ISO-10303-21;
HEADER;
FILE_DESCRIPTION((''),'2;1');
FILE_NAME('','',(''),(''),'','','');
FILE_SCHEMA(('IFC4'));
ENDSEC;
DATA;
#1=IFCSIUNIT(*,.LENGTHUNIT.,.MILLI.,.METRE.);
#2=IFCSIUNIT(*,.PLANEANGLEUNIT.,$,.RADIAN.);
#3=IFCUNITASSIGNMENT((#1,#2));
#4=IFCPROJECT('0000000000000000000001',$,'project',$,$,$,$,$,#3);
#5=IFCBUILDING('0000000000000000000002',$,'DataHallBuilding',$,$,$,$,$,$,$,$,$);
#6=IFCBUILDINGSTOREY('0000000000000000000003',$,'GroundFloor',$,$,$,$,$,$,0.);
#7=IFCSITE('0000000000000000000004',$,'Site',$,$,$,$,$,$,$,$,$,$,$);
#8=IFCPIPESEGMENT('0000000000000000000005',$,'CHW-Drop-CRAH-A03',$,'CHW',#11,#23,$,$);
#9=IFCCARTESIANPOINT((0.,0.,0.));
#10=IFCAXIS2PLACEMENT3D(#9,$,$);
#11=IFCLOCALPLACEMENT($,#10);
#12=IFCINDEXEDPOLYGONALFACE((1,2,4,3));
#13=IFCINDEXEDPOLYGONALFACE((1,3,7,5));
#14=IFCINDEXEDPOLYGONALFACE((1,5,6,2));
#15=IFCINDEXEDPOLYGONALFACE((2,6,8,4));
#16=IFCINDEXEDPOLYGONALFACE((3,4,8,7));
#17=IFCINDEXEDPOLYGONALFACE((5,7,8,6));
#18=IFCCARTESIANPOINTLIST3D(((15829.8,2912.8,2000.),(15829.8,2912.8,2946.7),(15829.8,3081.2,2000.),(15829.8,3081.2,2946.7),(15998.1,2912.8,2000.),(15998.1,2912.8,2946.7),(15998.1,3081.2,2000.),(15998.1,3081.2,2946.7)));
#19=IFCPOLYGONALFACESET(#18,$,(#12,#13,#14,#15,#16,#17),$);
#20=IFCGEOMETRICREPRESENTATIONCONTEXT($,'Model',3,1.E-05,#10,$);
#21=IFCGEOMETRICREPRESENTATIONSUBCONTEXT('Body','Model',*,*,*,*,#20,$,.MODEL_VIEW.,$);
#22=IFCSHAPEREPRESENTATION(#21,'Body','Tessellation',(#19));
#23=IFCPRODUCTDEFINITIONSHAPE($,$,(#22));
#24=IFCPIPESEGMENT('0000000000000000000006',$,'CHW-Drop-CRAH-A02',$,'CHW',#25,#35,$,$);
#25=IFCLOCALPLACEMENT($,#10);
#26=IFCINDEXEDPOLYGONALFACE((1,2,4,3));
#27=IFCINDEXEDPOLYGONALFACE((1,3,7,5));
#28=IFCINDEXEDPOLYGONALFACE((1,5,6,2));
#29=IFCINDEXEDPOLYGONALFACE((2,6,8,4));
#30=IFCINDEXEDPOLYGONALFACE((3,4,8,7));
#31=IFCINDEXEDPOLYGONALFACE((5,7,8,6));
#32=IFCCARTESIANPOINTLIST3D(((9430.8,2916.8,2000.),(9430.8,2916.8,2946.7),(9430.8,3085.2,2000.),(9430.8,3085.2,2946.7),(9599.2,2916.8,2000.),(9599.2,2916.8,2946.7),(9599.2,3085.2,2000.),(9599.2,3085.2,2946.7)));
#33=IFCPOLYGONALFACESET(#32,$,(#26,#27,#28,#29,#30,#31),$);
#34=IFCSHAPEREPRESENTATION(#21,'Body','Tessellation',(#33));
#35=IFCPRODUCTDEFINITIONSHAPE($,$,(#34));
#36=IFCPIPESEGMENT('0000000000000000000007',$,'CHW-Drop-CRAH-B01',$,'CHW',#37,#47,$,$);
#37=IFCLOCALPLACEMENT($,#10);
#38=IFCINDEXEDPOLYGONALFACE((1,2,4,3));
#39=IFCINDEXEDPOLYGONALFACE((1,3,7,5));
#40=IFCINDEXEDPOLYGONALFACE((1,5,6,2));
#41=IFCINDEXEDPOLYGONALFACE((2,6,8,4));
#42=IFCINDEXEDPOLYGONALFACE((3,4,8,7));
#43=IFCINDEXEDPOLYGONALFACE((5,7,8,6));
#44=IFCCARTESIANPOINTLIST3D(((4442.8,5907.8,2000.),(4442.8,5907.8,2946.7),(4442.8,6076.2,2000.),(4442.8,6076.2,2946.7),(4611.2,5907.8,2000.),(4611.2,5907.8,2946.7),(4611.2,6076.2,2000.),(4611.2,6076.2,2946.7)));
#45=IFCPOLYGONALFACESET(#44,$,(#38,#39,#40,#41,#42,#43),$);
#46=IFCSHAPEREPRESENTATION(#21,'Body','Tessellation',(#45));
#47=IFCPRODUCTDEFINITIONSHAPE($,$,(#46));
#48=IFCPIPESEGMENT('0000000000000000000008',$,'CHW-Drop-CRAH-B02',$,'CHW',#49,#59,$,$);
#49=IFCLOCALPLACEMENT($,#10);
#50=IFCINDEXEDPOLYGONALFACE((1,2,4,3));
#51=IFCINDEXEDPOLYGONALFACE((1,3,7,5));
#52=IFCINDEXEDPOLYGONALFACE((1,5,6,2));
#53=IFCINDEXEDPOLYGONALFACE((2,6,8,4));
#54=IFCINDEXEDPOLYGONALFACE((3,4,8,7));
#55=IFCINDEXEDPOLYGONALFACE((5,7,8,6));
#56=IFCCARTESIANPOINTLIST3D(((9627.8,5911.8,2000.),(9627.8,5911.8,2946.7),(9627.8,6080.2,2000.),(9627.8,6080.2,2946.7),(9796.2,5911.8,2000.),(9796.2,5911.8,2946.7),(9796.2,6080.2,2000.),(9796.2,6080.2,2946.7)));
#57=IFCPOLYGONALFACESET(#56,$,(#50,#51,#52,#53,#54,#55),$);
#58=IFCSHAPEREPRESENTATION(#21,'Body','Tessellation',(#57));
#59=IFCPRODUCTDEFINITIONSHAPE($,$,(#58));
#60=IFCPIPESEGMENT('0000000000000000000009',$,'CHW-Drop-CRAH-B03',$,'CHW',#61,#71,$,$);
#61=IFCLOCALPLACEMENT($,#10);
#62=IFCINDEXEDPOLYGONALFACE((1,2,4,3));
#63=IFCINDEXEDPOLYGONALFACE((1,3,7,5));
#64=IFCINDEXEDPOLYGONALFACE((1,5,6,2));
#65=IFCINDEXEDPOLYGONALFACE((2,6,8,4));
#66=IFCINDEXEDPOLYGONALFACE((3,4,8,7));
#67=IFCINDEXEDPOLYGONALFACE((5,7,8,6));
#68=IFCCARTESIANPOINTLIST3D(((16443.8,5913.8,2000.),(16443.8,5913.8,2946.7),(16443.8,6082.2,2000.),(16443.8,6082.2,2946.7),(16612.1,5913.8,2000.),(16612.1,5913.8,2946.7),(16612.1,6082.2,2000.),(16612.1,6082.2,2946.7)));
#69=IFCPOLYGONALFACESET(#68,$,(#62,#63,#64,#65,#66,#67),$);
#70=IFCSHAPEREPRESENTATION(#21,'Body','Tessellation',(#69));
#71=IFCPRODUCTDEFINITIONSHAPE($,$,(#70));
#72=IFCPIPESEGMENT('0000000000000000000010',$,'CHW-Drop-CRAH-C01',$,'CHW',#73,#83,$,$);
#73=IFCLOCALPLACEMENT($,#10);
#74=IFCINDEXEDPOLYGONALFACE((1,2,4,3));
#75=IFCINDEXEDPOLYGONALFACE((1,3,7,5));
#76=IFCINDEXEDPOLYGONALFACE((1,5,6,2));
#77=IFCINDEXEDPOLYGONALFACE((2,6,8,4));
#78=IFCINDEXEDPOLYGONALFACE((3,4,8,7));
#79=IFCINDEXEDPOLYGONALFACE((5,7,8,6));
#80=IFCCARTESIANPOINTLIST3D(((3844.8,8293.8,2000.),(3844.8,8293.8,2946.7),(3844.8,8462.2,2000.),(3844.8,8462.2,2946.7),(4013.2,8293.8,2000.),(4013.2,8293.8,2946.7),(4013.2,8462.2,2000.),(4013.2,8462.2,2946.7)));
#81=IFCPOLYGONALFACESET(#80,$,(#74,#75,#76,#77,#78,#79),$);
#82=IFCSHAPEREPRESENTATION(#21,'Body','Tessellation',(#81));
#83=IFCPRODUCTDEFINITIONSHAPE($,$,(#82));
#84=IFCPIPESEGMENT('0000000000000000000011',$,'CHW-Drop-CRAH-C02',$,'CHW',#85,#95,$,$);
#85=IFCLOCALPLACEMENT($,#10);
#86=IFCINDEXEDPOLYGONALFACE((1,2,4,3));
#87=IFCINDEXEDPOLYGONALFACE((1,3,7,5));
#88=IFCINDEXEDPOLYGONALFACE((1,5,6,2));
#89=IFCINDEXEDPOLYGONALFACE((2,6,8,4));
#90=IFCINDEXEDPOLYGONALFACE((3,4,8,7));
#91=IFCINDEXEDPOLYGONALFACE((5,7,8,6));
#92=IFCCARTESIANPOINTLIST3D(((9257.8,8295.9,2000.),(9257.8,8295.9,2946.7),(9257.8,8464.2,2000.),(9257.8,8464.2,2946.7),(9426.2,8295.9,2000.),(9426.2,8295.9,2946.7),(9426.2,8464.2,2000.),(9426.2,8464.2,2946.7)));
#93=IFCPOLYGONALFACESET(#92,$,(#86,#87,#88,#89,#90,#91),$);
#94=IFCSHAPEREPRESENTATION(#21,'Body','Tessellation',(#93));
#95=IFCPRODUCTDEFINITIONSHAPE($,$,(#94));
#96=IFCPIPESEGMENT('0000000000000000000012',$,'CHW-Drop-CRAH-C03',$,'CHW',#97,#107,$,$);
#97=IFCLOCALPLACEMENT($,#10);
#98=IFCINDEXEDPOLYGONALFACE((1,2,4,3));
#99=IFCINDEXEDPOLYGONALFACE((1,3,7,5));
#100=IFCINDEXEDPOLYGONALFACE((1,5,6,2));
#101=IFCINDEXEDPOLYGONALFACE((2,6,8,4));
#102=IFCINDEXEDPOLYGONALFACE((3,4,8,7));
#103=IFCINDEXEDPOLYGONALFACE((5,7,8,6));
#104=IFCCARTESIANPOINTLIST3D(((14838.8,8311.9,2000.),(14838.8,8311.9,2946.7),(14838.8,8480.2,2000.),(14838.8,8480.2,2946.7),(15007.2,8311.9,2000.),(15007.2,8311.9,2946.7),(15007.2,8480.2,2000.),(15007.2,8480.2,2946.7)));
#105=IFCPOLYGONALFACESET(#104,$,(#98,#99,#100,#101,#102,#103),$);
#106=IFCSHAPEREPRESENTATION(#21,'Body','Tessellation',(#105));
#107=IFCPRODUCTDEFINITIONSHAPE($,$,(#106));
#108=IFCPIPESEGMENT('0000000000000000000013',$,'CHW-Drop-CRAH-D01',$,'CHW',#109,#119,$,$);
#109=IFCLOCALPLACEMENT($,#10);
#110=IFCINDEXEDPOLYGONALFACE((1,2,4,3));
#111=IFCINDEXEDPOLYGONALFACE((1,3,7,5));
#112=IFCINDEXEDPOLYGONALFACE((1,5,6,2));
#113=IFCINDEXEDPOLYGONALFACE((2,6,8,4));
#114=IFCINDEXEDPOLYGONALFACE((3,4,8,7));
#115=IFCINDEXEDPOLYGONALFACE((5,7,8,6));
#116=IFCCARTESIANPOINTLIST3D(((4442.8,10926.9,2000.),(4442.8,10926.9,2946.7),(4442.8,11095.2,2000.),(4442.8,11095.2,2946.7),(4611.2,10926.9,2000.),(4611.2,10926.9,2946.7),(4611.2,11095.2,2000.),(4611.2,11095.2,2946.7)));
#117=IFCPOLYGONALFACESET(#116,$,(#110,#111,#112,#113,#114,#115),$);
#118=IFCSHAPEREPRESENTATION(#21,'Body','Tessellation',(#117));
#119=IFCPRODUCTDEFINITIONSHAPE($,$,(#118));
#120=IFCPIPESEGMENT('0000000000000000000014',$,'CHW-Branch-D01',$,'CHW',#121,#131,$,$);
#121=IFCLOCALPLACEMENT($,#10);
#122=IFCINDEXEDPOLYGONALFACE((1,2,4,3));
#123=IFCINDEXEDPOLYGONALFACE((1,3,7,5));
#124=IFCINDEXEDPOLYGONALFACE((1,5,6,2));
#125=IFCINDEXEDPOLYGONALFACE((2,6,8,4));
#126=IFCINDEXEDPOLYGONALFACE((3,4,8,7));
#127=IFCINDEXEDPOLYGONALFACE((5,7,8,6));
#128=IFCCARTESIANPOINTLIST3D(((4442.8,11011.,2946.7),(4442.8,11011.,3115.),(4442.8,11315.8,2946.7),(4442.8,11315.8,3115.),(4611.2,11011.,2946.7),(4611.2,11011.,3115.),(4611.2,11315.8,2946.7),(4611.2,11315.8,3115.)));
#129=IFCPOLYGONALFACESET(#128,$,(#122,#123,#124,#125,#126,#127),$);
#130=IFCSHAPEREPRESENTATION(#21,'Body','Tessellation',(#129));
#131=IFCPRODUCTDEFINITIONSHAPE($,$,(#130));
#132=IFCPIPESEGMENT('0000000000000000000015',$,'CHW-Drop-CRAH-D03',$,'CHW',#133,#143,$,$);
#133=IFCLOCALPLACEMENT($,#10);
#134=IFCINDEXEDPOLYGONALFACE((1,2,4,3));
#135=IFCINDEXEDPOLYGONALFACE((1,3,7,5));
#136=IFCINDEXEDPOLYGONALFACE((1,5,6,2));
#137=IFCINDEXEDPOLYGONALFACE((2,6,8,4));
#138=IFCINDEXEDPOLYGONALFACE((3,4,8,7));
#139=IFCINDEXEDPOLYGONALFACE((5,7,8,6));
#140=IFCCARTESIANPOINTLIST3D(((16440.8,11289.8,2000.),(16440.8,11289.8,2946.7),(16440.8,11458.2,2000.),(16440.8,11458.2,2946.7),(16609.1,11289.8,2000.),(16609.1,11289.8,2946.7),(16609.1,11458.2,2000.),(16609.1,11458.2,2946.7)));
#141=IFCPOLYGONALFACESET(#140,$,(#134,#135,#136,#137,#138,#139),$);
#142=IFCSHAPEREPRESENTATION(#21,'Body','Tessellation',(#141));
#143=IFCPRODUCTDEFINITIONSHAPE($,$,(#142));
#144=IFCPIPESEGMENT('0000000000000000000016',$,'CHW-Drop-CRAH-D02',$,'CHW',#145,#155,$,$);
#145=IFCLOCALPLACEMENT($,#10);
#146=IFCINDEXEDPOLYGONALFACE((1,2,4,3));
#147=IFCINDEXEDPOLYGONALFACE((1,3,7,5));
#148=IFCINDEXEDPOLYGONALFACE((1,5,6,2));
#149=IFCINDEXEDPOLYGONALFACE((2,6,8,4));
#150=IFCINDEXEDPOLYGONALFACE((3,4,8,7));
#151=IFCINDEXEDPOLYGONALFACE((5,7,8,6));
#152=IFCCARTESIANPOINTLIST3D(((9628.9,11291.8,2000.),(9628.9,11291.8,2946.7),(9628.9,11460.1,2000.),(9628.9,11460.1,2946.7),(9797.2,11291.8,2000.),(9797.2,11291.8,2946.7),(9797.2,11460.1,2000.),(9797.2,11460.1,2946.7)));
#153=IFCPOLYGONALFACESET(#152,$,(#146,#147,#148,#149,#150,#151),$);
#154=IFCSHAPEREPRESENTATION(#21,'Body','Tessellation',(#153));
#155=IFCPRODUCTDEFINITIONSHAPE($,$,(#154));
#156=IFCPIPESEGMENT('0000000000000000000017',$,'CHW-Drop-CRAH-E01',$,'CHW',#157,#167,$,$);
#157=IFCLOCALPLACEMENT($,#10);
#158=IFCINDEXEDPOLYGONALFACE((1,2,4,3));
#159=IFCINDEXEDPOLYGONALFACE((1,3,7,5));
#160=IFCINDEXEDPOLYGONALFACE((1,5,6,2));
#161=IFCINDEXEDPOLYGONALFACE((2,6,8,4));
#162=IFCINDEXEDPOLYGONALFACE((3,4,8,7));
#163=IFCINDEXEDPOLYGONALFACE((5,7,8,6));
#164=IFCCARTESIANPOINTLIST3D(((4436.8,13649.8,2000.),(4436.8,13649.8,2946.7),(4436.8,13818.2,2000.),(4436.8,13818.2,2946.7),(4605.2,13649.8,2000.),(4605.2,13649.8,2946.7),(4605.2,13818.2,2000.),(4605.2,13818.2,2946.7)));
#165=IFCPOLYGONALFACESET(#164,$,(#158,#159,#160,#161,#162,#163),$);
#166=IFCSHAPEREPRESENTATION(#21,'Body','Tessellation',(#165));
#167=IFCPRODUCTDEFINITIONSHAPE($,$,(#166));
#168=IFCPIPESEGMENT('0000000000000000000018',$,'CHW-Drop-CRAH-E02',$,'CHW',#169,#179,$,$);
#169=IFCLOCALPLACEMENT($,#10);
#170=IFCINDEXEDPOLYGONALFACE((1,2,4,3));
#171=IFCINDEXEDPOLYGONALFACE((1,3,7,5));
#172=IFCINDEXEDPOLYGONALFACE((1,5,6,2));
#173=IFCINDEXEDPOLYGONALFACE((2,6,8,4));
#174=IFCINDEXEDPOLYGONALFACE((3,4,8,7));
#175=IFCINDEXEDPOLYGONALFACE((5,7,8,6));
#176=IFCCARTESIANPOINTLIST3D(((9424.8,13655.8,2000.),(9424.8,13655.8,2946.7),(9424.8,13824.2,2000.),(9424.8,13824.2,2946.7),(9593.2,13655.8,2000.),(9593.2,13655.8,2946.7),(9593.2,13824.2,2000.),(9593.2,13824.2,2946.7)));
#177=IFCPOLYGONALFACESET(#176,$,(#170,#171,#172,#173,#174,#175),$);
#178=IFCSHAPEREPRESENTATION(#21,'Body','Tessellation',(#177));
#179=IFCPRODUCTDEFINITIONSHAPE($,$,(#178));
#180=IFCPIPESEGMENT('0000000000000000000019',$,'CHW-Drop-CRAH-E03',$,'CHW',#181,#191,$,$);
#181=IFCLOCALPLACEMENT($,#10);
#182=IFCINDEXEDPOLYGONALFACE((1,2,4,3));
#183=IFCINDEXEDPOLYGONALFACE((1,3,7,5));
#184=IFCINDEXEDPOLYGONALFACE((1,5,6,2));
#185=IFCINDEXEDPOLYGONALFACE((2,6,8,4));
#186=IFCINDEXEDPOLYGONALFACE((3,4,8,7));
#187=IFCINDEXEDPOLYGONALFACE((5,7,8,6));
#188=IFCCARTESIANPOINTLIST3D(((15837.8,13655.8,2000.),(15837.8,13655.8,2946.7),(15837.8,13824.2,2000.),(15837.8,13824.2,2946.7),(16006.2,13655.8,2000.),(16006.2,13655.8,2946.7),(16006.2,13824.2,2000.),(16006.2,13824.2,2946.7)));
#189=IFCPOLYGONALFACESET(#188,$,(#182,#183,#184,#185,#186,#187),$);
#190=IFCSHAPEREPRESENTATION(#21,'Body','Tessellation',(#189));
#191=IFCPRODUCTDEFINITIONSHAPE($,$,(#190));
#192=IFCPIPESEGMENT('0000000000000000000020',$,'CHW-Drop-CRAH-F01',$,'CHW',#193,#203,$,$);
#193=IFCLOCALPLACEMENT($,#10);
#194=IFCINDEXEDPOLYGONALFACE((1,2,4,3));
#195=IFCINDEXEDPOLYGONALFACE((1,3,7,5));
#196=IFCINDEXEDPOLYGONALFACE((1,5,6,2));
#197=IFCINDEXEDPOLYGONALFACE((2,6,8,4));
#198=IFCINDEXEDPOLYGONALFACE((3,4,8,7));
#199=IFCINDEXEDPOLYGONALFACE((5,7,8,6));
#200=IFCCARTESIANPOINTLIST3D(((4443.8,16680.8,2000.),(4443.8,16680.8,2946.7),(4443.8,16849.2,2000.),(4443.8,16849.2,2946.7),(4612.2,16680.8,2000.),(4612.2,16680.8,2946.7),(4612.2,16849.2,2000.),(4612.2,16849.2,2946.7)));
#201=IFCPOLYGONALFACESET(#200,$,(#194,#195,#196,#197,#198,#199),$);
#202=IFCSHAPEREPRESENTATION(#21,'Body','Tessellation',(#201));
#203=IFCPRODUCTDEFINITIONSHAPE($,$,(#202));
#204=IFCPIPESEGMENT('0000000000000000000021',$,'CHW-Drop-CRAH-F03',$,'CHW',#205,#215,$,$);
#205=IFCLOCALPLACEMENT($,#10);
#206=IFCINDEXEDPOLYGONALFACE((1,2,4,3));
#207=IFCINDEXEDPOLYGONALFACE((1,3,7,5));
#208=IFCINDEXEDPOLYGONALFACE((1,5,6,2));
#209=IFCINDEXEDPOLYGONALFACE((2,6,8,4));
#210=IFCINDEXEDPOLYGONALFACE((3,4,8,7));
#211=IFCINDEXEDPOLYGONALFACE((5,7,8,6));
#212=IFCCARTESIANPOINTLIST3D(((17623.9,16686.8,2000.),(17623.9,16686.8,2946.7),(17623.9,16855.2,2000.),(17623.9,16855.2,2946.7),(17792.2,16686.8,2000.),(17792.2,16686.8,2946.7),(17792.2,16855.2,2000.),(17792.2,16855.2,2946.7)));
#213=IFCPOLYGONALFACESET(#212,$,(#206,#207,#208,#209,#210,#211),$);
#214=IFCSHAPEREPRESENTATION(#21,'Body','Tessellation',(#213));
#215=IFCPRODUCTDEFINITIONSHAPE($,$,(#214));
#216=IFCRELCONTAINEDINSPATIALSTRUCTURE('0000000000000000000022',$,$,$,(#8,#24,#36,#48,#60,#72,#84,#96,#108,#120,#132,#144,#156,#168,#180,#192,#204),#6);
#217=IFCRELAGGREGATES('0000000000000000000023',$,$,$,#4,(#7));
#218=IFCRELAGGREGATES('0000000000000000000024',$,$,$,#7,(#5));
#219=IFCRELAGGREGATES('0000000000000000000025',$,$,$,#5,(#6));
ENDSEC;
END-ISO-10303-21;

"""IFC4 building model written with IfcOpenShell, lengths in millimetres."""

from ifc_helpers import new_model, si_unit, frame, origin, place, context, subcontext, project, spatial, rectangle, extrude, element, save


model = new_model("IFC4")

# Units and contexts
model_context = context("Model", 3, precision=1e-05, world=origin())
body_context = subcontext(model_context, "Body", "Model", "MODEL_VIEW")
ifc_project = project(units=[si_unit("LENGTHUNIT", "METRE", prefix="MILLI"), si_unit("PLANEANGLEUNIT", "RADIAN")])

# Site, building, storey
site = spatial("IfcSite", under=ifc_project, Name="Site")
building = spatial("IfcBuilding", under=site, Name="DataHallBuilding")
storey = spatial("IfcBuildingStorey", under=building, Name="GroundFloor", Elevation=0.0)

# Pipe segments
pipe_segment_1_placement = place(None, origin())
element("IfcPipeSegment", 1, at=pipe_segment_1_placement, inside=storey, Name="CHW-Drop-CRAH-A03", ObjectType="CHW", context=body_context, shape_type="SweptSolid", body=[
    extrude(rectangle(XDim=168.3, YDim=168.3), frame((15914.0, 2997.0, 2000.0), z_axis=(0.0, 0.0, 1.0), x_axis=(1.0, 0.0, 0.0)), (0.0, 0.0, 1.0), 946.7),
])
pipe_segment_2_placement = place(None, origin())
element("IfcPipeSegment", 2, at=pipe_segment_2_placement, inside=storey, Name="CHW-Drop-CRAH-A02", ObjectType="CHW", context=body_context, shape_type="SweptSolid", body=[
    extrude(rectangle(XDim=168.3, YDim=168.3), frame((9515.0, 3001.0, 2000.0), z_axis=(0.0, 0.0, 1.0), x_axis=(1.0, 0.0, 0.0)), (0.0, 0.0, 1.0), 946.7),
])
pipe_segment_3_placement = place(None, origin())
element("IfcPipeSegment", 3, at=pipe_segment_3_placement, inside=storey, Name="CHW-Drop-CRAH-B01", ObjectType="CHW", context=body_context, shape_type="SweptSolid", body=[
    extrude(rectangle(XDim=168.3, YDim=168.3), frame((4527.0, 5992.0, 2000.0), z_axis=(0.0, 0.0, 1.0), x_axis=(1.0, 0.0, 0.0)), (0.0, 0.0, 1.0), 946.7),
])
pipe_segment_4_placement = place(None, origin())
element("IfcPipeSegment", 4, at=pipe_segment_4_placement, inside=storey, Name="CHW-Drop-CRAH-B02", ObjectType="CHW", context=body_context, shape_type="SweptSolid", body=[
    extrude(rectangle(XDim=168.3, YDim=168.3), frame((9712.0, 5996.0, 2000.0), z_axis=(0.0, 0.0, 1.0), x_axis=(1.0, 0.0, 0.0)), (0.0, 0.0, 1.0), 946.7),
])
pipe_segment_5_placement = place(None, origin())
element("IfcPipeSegment", 5, at=pipe_segment_5_placement, inside=storey, Name="CHW-Drop-CRAH-B03", ObjectType="CHW", context=body_context, shape_type="SweptSolid", body=[
    extrude(rectangle(XDim=168.3, YDim=168.3), frame((16528.0, 5998.0, 2000.0), z_axis=(0.0, 0.0, 1.0), x_axis=(1.0, 0.0, 0.0)), (0.0, 0.0, 1.0), 946.7),
])
pipe_segment_6_placement = place(None, origin())
element("IfcPipeSegment", 6, at=pipe_segment_6_placement, inside=storey, Name="CHW-Drop-CRAH-C01", ObjectType="CHW", context=body_context, shape_type="SweptSolid", body=[
    extrude(rectangle(XDim=168.3, YDim=168.3), frame((3929.0, 8378.0, 2000.0), z_axis=(0.0, 0.0, 1.0), x_axis=(1.0, 0.0, 0.0)), (0.0, 0.0, 1.0), 946.7),
])
pipe_segment_7_placement = place(None, origin())
element("IfcPipeSegment", 7, at=pipe_segment_7_placement, inside=storey, Name="CHW-Drop-CRAH-C02", ObjectType="CHW", context=body_context, shape_type="SweptSolid", body=[
    extrude(rectangle(XDim=168.3, YDim=168.3), frame((9342.0, 8380.0, 2000.0), z_axis=(0.0, 0.0, 1.0), x_axis=(1.0, 0.0, 0.0)), (0.0, 0.0, 1.0), 946.7),
])
pipe_segment_8_placement = place(None, origin())
element("IfcPipeSegment", 8, at=pipe_segment_8_placement, inside=storey, Name="CHW-Drop-CRAH-C03", ObjectType="CHW", context=body_context, shape_type="SweptSolid", body=[
    extrude(rectangle(XDim=168.3, YDim=168.3), frame((14923.0, 8396.0, 2000.0), z_axis=(0.0, 0.0, 1.0), x_axis=(1.0, 0.0, 0.0)), (0.0, 0.0, 1.0), 946.7),
])
pipe_segment_9_placement = place(None, origin())
element("IfcPipeSegment", 9, at=pipe_segment_9_placement, inside=storey, Name="CHW-Drop-CRAH-D01", ObjectType="CHW", context=body_context, shape_type="SweptSolid", body=[
    extrude(rectangle(XDim=168.3, YDim=168.3), frame((4527.0, 11011.0, 2000.0), z_axis=(0.0, 0.0, 1.0), x_axis=(1.0, 0.0, 0.0)), (0.0, 0.0, 1.0), 946.7),
])
pipe_segment_10_placement = place(None, origin())
element("IfcPipeSegment", 10, at=pipe_segment_10_placement, inside=storey, Name="CHW-Branch-D01", ObjectType="CHW", context=body_context, shape_type="SweptSolid", body=[
    extrude(rectangle(XDim=168.3, YDim=304.9), frame((4527.0, 11163.4, 2946.7), z_axis=(0.0, 0.0, 1.0), x_axis=(1.0, 0.0, 0.0)), (0.0, 0.0, 1.0), 168.3),
])
pipe_segment_11_placement = place(None, origin())
element("IfcPipeSegment", 11, at=pipe_segment_11_placement, inside=storey, Name="CHW-Drop-CRAH-D03", ObjectType="CHW", context=body_context, shape_type="SweptSolid", body=[
    extrude(rectangle(XDim=168.3, YDim=168.3), frame((16525.0, 11374.0, 2000.0), z_axis=(0.0, 0.0, 1.0), x_axis=(1.0, 0.0, 0.0)), (0.0, 0.0, 1.0), 946.7),
])
pipe_segment_12_placement = place(None, origin())
element("IfcPipeSegment", 12, at=pipe_segment_12_placement, inside=storey, Name="CHW-Drop-CRAH-D02", ObjectType="CHW", context=body_context, shape_type="SweptSolid", body=[
    extrude(rectangle(XDim=168.3, YDim=168.3), frame((9713.0, 11376.0, 2000.0), z_axis=(0.0, 0.0, 1.0), x_axis=(1.0, 0.0, 0.0)), (0.0, 0.0, 1.0), 946.7),
])
pipe_segment_13_placement = place(None, origin())
element("IfcPipeSegment", 13, at=pipe_segment_13_placement, inside=storey, Name="CHW-Drop-CRAH-E01", ObjectType="CHW", context=body_context, shape_type="SweptSolid", body=[
    extrude(rectangle(XDim=168.3, YDim=168.3), frame((4521.0, 13734.0, 2000.0), z_axis=(0.0, 0.0, 1.0), x_axis=(1.0, 0.0, 0.0)), (0.0, 0.0, 1.0), 946.7),
])
pipe_segment_14_placement = place(None, origin())
element("IfcPipeSegment", 14, at=pipe_segment_14_placement, inside=storey, Name="CHW-Drop-CRAH-E02", ObjectType="CHW", context=body_context, shape_type="SweptSolid", body=[
    extrude(rectangle(XDim=168.3, YDim=168.3), frame((9509.0, 13740.0, 2000.0), z_axis=(0.0, 0.0, 1.0), x_axis=(1.0, 0.0, 0.0)), (0.0, 0.0, 1.0), 946.7),
])
pipe_segment_15_placement = place(None, origin())
element("IfcPipeSegment", 15, at=pipe_segment_15_placement, inside=storey, Name="CHW-Drop-CRAH-E03", ObjectType="CHW", context=body_context, shape_type="SweptSolid", body=[
    extrude(rectangle(XDim=168.3, YDim=168.3), frame((15922.0, 13740.0, 2000.0), z_axis=(0.0, 0.0, 1.0), x_axis=(1.0, 0.0, 0.0)), (0.0, 0.0, 1.0), 946.7),
])
pipe_segment_16_placement = place(None, origin())
element("IfcPipeSegment", 16, at=pipe_segment_16_placement, inside=storey, Name="CHW-Drop-CRAH-F01", ObjectType="CHW", context=body_context, shape_type="SweptSolid", body=[
    extrude(rectangle(XDim=168.3, YDim=168.3), frame((4528.0, 16765.0, 2000.0), z_axis=(0.0, 0.0, 1.0), x_axis=(1.0, 0.0, 0.0)), (0.0, 0.0, 1.0), 946.7),
])
pipe_segment_17_placement = place(None, origin())
element("IfcPipeSegment", 17, at=pipe_segment_17_placement, inside=storey, Name="CHW-Drop-CRAH-F03", ObjectType="CHW", context=body_context, shape_type="SweptSolid", body=[
    extrude(rectangle(XDim=168.3, YDim=168.3), frame((17708.0, 16771.0, 2000.0), z_axis=(0.0, 0.0, 1.0), x_axis=(1.0, 0.0, 0.0)), (0.0, 0.0, 1.0), 946.7),
])

save(model, "model.ifc")
